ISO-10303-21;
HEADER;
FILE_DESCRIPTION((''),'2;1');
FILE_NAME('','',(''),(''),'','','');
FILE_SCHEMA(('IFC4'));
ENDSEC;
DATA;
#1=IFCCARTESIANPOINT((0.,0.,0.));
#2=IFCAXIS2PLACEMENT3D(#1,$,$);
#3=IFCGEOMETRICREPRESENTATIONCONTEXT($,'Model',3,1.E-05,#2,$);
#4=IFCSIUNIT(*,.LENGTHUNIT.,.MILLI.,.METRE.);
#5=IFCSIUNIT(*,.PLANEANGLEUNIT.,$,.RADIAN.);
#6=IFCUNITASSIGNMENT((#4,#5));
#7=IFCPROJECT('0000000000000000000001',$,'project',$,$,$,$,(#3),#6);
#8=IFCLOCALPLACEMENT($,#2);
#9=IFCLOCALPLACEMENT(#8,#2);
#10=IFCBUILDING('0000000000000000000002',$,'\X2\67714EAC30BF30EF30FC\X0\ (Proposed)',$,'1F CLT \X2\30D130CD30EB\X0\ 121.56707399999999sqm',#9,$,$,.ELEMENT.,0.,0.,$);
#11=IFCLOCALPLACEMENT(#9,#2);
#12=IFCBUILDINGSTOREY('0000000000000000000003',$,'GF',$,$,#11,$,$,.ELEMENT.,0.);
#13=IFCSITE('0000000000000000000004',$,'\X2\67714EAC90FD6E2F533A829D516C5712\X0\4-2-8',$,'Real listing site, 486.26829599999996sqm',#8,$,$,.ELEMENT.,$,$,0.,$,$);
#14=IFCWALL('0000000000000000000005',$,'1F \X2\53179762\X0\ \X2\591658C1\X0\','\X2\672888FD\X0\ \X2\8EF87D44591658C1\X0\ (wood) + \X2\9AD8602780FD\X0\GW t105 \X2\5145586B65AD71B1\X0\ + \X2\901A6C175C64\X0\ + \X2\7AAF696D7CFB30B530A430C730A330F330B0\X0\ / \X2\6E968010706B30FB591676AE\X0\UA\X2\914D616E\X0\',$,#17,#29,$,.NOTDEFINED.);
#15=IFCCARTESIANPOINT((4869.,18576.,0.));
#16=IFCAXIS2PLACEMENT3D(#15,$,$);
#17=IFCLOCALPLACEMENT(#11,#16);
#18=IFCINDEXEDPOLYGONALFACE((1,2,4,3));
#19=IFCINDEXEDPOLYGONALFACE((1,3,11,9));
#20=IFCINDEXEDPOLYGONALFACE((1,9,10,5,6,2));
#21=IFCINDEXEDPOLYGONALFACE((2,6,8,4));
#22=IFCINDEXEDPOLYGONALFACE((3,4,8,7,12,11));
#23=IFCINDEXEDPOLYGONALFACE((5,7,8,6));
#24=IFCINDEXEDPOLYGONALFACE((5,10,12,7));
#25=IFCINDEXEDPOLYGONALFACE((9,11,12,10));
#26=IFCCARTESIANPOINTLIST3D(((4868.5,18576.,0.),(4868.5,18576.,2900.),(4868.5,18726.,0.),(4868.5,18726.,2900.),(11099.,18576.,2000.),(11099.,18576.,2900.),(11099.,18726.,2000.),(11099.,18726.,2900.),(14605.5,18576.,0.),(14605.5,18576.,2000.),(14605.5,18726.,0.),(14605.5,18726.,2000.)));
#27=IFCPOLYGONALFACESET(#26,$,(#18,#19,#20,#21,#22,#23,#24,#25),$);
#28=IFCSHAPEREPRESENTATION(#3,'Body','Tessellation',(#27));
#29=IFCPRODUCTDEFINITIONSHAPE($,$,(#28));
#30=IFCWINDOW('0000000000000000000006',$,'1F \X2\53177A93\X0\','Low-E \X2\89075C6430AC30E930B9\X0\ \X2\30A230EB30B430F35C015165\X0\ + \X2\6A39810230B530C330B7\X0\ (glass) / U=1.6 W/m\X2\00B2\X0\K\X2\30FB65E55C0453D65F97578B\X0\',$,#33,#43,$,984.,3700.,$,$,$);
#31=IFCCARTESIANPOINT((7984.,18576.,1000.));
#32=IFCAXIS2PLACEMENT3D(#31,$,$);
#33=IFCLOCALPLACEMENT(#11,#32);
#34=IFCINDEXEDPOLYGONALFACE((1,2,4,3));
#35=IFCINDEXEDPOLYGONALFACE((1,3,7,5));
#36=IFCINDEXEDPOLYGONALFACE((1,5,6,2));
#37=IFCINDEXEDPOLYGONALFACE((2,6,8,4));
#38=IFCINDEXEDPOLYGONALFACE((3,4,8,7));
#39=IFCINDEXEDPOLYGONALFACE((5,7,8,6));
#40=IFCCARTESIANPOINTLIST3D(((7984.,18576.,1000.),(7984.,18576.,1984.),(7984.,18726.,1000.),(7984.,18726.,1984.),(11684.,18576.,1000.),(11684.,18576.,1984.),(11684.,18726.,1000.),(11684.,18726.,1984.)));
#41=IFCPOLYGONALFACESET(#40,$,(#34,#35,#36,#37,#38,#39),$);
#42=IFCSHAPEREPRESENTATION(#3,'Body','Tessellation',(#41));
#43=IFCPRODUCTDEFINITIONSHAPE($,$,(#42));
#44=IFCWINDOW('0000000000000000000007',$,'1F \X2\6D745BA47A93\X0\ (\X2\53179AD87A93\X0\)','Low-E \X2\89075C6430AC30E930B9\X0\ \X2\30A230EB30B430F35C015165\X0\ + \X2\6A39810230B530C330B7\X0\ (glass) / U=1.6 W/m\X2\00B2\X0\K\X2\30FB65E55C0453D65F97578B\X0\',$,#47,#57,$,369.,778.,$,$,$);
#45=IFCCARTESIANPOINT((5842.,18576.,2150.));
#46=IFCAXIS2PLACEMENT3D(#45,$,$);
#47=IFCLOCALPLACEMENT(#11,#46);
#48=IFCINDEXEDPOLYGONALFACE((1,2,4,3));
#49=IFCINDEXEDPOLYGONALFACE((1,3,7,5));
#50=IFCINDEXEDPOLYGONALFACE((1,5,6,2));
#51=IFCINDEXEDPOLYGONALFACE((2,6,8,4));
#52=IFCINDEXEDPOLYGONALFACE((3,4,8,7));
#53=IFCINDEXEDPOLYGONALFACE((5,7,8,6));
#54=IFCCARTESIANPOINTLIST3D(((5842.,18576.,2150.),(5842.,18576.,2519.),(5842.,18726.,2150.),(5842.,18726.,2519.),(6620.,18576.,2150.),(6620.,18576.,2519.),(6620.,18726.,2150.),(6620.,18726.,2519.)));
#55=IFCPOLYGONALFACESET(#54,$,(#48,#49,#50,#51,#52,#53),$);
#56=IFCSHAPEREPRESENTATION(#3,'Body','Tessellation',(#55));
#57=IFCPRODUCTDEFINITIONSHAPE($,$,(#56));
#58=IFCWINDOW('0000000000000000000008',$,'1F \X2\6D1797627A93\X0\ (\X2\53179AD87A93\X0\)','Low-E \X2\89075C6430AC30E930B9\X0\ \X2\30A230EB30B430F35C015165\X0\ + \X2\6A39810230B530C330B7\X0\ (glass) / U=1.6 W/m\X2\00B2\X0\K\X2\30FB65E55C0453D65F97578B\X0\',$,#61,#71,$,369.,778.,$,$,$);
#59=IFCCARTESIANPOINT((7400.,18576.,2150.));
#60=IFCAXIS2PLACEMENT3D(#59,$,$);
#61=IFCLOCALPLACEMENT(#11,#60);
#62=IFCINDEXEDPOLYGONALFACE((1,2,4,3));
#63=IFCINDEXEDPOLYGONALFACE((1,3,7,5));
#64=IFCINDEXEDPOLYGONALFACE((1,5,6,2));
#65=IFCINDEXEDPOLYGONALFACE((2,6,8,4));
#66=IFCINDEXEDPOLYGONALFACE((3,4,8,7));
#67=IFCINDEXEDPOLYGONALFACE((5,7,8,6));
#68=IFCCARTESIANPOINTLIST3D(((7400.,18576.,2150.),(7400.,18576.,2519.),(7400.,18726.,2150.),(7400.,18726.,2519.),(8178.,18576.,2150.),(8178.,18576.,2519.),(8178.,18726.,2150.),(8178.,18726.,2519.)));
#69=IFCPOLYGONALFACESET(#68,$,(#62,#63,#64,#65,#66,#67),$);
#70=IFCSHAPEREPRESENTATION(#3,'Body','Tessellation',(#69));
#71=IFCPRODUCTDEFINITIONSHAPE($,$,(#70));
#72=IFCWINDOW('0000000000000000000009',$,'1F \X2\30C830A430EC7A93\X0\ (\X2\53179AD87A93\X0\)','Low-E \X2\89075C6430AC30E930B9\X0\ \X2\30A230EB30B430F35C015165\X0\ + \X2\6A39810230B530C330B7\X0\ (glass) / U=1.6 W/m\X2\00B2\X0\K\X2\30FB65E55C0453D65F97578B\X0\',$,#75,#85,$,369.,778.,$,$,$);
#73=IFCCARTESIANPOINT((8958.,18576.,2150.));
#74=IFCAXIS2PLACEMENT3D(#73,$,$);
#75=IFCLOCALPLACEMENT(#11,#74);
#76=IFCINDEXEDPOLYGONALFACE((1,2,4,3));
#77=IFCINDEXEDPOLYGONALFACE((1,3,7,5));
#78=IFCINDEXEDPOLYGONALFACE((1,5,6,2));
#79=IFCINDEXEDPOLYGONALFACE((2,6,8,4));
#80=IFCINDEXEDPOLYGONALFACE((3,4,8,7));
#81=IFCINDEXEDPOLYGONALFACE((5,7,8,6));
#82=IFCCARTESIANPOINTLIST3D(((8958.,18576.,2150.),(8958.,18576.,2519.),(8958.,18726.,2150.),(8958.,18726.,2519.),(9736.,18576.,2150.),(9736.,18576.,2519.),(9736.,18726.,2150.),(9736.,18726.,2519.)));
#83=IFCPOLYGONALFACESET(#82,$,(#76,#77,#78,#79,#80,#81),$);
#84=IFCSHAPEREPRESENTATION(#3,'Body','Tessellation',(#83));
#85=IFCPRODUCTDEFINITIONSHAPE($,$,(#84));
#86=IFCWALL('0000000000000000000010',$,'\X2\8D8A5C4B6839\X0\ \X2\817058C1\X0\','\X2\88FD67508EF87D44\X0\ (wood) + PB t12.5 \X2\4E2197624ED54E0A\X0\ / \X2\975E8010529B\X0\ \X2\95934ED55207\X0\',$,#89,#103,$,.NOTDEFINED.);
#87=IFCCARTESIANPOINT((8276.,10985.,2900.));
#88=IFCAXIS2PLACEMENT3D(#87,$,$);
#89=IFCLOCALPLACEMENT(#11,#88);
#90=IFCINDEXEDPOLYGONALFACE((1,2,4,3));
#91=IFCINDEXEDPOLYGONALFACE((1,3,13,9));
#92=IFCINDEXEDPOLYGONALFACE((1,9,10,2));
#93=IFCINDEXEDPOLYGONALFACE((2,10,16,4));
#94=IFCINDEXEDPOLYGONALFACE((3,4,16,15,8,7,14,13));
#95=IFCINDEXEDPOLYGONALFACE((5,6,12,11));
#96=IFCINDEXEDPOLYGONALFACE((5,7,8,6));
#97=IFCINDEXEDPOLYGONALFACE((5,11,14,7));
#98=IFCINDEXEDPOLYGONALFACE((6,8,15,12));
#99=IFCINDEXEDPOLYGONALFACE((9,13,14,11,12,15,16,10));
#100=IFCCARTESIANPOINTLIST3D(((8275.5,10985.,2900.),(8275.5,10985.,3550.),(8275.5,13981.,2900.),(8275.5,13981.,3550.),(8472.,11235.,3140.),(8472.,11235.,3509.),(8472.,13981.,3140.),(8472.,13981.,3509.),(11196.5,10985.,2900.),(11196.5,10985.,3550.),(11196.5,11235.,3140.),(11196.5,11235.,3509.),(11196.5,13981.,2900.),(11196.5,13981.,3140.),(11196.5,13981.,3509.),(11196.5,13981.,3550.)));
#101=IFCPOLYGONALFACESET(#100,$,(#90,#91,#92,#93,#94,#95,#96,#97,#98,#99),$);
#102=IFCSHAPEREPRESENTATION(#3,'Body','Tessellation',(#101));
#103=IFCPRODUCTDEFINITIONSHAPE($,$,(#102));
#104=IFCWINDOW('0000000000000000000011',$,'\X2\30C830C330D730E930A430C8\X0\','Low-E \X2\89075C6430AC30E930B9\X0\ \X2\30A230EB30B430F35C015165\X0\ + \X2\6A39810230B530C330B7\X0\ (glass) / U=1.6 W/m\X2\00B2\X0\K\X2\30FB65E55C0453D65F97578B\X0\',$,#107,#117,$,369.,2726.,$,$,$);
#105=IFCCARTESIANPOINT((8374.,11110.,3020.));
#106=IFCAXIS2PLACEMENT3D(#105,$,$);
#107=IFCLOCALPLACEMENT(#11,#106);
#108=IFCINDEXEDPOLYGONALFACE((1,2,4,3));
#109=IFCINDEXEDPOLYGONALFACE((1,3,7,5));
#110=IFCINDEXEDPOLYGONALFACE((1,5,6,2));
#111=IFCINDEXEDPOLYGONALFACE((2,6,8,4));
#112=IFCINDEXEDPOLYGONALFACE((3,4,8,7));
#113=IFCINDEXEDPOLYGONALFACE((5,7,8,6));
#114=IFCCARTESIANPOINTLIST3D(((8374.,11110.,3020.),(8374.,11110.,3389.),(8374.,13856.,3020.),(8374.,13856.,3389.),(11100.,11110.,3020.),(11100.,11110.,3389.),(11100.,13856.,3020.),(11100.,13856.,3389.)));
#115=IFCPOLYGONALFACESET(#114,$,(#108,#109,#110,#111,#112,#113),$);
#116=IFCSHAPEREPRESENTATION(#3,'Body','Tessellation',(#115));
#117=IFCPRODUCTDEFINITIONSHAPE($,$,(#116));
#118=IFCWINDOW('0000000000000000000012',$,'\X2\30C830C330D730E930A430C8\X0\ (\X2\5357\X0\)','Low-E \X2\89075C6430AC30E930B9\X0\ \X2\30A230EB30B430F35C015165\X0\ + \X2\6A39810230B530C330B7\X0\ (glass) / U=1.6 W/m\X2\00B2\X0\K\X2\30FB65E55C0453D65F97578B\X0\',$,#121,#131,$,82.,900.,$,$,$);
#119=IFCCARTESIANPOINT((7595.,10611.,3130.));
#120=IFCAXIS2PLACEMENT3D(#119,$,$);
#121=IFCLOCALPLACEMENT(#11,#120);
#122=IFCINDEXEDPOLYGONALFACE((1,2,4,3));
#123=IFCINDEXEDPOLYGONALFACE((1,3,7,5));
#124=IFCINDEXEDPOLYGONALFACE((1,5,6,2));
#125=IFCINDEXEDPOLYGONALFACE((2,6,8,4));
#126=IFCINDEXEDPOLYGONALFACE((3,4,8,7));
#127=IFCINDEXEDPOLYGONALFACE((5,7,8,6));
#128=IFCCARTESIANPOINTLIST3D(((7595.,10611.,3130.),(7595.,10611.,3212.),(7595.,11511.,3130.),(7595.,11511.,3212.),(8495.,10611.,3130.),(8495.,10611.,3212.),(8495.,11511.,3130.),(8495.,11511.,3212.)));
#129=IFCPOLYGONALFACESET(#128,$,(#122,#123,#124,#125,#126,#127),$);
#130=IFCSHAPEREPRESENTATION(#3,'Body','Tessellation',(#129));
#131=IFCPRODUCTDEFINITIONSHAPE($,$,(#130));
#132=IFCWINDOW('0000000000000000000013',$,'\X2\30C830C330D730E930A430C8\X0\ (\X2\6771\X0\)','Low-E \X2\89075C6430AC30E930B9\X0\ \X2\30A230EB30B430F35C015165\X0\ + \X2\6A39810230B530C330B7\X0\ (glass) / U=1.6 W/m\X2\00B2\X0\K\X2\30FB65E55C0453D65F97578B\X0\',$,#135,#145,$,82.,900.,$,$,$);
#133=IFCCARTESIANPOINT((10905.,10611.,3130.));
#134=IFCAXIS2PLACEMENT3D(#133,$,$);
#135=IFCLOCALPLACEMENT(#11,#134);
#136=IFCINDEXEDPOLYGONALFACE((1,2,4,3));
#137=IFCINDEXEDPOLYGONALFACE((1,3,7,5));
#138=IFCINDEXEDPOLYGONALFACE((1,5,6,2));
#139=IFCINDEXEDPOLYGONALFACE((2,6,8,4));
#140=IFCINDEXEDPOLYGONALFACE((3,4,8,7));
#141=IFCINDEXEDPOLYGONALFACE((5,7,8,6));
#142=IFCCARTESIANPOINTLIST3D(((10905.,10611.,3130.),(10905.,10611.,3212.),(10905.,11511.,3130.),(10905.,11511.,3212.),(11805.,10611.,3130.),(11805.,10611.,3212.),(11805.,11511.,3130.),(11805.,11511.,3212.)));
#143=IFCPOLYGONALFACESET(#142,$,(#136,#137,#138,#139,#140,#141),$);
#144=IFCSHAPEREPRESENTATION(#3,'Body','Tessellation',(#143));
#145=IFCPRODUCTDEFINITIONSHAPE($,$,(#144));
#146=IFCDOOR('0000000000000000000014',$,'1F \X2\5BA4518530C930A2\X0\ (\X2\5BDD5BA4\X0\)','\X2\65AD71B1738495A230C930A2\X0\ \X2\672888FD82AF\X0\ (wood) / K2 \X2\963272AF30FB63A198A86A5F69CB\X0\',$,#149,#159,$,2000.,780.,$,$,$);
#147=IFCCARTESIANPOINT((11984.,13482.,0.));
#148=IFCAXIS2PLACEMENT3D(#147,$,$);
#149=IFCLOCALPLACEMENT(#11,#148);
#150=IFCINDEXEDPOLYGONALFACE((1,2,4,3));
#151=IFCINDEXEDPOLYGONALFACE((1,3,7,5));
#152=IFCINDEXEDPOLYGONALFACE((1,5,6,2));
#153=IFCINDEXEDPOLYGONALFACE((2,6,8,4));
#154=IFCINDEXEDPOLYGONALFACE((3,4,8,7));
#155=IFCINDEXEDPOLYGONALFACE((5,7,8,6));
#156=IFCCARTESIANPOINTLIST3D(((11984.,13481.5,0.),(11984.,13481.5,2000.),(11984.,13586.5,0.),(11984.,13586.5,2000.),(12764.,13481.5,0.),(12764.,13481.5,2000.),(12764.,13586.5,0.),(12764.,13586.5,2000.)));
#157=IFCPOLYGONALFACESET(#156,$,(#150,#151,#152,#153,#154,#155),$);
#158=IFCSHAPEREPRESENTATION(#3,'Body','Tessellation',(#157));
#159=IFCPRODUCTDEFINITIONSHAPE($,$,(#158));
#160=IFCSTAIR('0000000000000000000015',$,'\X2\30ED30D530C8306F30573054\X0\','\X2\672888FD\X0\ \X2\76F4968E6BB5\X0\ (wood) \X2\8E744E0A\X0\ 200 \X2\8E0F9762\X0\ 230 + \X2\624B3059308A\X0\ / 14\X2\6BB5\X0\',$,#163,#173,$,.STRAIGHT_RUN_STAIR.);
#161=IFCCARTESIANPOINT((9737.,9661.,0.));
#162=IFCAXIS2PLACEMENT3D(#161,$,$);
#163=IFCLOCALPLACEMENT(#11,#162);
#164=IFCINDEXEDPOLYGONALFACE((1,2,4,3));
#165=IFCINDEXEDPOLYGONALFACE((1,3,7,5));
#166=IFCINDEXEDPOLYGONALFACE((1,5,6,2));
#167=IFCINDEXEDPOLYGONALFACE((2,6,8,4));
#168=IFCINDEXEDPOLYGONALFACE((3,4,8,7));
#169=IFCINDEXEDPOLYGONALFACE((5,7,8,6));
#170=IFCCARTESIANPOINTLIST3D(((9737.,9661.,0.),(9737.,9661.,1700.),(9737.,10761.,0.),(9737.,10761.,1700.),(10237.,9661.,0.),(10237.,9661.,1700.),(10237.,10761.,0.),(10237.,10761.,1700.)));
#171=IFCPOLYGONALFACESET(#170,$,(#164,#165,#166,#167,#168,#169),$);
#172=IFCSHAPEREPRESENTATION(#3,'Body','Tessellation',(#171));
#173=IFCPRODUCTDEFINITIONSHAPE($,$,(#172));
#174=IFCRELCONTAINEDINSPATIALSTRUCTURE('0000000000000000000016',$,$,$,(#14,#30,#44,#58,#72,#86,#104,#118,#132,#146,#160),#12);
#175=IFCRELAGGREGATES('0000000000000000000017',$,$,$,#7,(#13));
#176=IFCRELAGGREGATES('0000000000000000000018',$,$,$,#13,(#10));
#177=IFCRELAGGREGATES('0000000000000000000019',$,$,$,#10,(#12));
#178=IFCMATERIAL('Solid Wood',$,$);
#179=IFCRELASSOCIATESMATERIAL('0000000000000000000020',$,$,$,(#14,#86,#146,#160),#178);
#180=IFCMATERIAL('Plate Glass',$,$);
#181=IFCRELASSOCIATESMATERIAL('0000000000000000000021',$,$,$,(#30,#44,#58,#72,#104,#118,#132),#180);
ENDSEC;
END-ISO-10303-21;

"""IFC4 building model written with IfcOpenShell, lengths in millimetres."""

from ifc_helpers import new_model, si_unit, frame, frame_2d, origin, place, context, project, spatial, rectangle, extrude, material, element, fill, save


model = new_model("IFC4")

# Units and contexts
model_context = context("Model", 3, precision=1e-05, world=origin())
ifc_project = project(units=[si_unit("LENGTHUNIT", "METRE", prefix="MILLI"), si_unit("PLANEANGLEUNIT", "RADIAN")], contexts=[model_context])

# Site, building, storey
site_placement = place(None, origin())
site = spatial("IfcSite", under=ifc_project, at=site_placement, Name="東京都港区芝公園4-2-8", ObjectType="Real listing site, 486.26829599999996sqm", CompositionType="ELEMENT", RefElevation=0.0)
building_placement = place(site_placement, origin())
building = spatial("IfcBuilding", under=site, at=building_placement, Name="東京タワー (Proposed)", ObjectType="1F CLT パネル 121.56707399999999sqm", CompositionType="ELEMENT", ElevationOfRefHeight=0.0, ElevationOfTerrain=0.0)
storey_placement = place(building_placement, origin())
storey = spatial("IfcBuildingStorey", under=building, at=storey_placement, Name="GF", CompositionType="ELEMENT", Elevation=0.0)

# Shared definitions
ifc_material_1 = material(Name="Solid Wood")

# Wall, openings, windows
wall_1_placement = place(storey_placement, frame((4869.0, 18576.0, 0.0)))
wall_1 = element("IfcWall", 1, at=wall_1_placement, inside=storey, material=ifc_material_1, Name="1F 北面 外壁", Description="木製 軸組外壁 (wood) + 高性能GW t105 充填断熱 + 通気層 + 窯業系サイディング / 準耐火・外皮UA配慮", PredefinedType="NOTDEFINED", context=model_context, shape_type="SweptSolid", body=[
    extrude(rectangle(XDim=9737.0, YDim=150.0, at=frame_2d((4868.0, 75.0))), frame((4869.0, 18576.0, 0.0)), (0.0, 0.0, 1.0), 2900.0),
])
opening_1_placement = place(storey_placement, frame((7984.0, 18576.0, 1000.0)))
opening_1 = element("IfcOpeningElement", 2, at=opening_1_placement, cuts=wall_1, PredefinedType="NOTDEFINED", context=model_context, shape_type="SweptSolid", body=[
    extrude(rectangle(XDim=3700.0, YDim=150.0, at=frame_2d((1850.0, 75.0))), frame((7984.0, 18576.0, 1000.0)), (0.0, 0.0, 1.0), 984.0),
])
opening_2_placement = place(storey_placement, frame((5842.0, 18576.0, 2150.0)))
opening_2 = element("IfcOpeningElement", 3, at=opening_2_placement, cuts=wall_1, PredefinedType="NOTDEFINED", context=model_context, shape_type="SweptSolid", body=[
    extrude(rectangle(XDim=778.0, YDim=150.0, at=frame_2d((389.0, 75.0))), frame((5842.0, 18576.0, 2150.0)), (0.0, 0.0, 1.0), 369.0),
])
opening_3_placement = place(storey_placement, frame((7400.0, 18576.0, 2150.0)))
opening_3 = element("IfcOpeningElement", 4, at=opening_3_placement, cuts=wall_1, PredefinedType="NOTDEFINED", context=model_context, shape_type="SweptSolid", body=[
    extrude(rectangle(XDim=778.0, YDim=150.0, at=frame_2d((389.0, 75.0))), frame((7400.0, 18576.0, 2150.0)), (0.0, 0.0, 1.0), 369.0),
])
opening_4_placement = place(storey_placement, frame((8958.0, 18576.0, 2150.0)))
opening_4 = element("IfcOpeningElement", 5, at=opening_4_placement, cuts=wall_1, PredefinedType="NOTDEFINED", context=model_context, shape_type="SweptSolid", body=[
    extrude(rectangle(XDim=778.0, YDim=150.0, at=frame_2d((389.0, 75.0))), frame((8958.0, 18576.0, 2150.0)), (0.0, 0.0, 1.0), 369.0),
])
ifc_material_2 = material(Name="Plate Glass")
window_1_placement = place(storey_placement, frame((7984.0, 18576.0, 1000.0)))
window_1 = element("IfcWindow", 6, at=window_1_placement, inside=storey, material=ifc_material_2, Name="1F 北窓", Description="Low-E 複層ガラス アルゴン封入 + 樹脂サッシ (glass) / U=1.6 W/m²K・日射取得型", OverallHeight=984.0, OverallWidth=3700.0, context=model_context, shape_type="SweptSolid", body=[
    extrude(rectangle(XDim=3700.0, YDim=150.0, at=frame_2d((1850.0, 75.0))), frame((7984.0, 18576.0, 1000.0)), (0.0, 0.0, 1.0), 984.0),
])
fill(opening_1, window_1)
window_2_placement = place(storey_placement, frame((5842.0, 18576.0, 2150.0)))
window_2 = element("IfcWindow", 7, at=window_2_placement, inside=storey, material=ifc_material_2, Name="1F 浴室窓 (北高窓)", Description="Low-E 複層ガラス アルゴン封入 + 樹脂サッシ (glass) / U=1.6 W/m²K・日射取得型", OverallHeight=369.0, OverallWidth=778.0, context=model_context, shape_type="SweptSolid", body=[
    extrude(rectangle(XDim=778.0, YDim=150.0, at=frame_2d((389.0, 75.0))), frame((5842.0, 18576.0, 2150.0)), (0.0, 0.0, 1.0), 369.0),
])
fill(opening_2, window_2)
window_3_placement = place(storey_placement, frame((7400.0, 18576.0, 2150.0)))
window_3 = element("IfcWindow", 8, at=window_3_placement, inside=storey, material=ifc_material_2, Name="1F 洗面窓 (北高窓)", Description="Low-E 複層ガラス アルゴン封入 + 樹脂サッシ (glass) / U=1.6 W/m²K・日射取得型", OverallHeight=369.0, OverallWidth=778.0, context=model_context, shape_type="SweptSolid", body=[
    extrude(rectangle(XDim=778.0, YDim=150.0, at=frame_2d((389.0, 75.0))), frame((7400.0, 18576.0, 2150.0)), (0.0, 0.0, 1.0), 369.0),
])
fill(opening_3, window_3)
window_4_placement = place(storey_placement, frame((8958.0, 18576.0, 2150.0)))
window_4 = element("IfcWindow", 9, at=window_4_placement, inside=storey, material=ifc_material_2, Name="1F トイレ窓 (北高窓)", Description="Low-E 複層ガラス アルゴン封入 + 樹脂サッシ (glass) / U=1.6 W/m²K・日射取得型", OverallHeight=369.0, OverallWidth=778.0, context=model_context, shape_type="SweptSolid", body=[
    extrude(rectangle(XDim=778.0, YDim=150.0, at=frame_2d((389.0, 75.0))), frame((8958.0, 18576.0, 2150.0)), (0.0, 0.0, 1.0), 369.0),
])
fill(opening_4, window_4)

# Wall, openings, windows
wall_2_placement = place(storey_placement, frame((8276.0, 10985.0, 2900.0)))
wall_2 = element("IfcWall", 10, at=wall_2_placement, inside=storey, material=ifc_material_1, Name="越屋根 腰壁", Description="製材軸組 (wood) + PB t12.5 両面仕上 / 非耐力 間仕切", PredefinedType="NOTDEFINED", context=model_context, shape_type="SweptSolid", body=[
    extrude(rectangle(XDim=2921.0, YDim=2996.0, at=frame_2d((1460.0, 1498.0))), frame((8276.0, 10985.0, 2900.0)), (0.0, 0.0, 1.0), 650.0),
])
opening_5_placement = place(storey_placement, frame((8374.0, 11110.0, 3020.0)))
opening_5 = element("IfcOpeningElement", 11, at=opening_5_placement, cuts=wall_2, PredefinedType="NOTDEFINED", context=model_context, shape_type="SweptSolid", body=[
    extrude(rectangle(XDim=2726.0, YDim=2746.0, at=frame_2d((1363.0, 1373.0))), frame((8374.0, 11110.0, 3020.0)), (0.0, 0.0, 1.0), 369.0),
])
opening_6_placement = place(storey_placement, frame((7595.0, 10611.0, 3130.0)))
opening_6 = element("IfcOpeningElement", 12, at=opening_6_placement, cuts=wall_2, PredefinedType="NOTDEFINED", context=model_context, shape_type="SweptSolid", body=[
    extrude(rectangle(XDim=900.0, YDim=900.0, at=frame_2d((450.0, 450.0))), frame((7595.0, 10611.0, 3130.0)), (0.0, 0.0, 1.0), 82.0),
])
opening_7_placement = place(storey_placement, frame((10905.0, 10611.0, 3130.0)))
opening_7 = element("IfcOpeningElement", 13, at=opening_7_placement, cuts=wall_2, PredefinedType="NOTDEFINED", context=model_context, shape_type="SweptSolid", body=[
    extrude(rectangle(XDim=900.0, YDim=900.0, at=frame_2d((450.0, 450.0))), frame((10905.0, 10611.0, 3130.0)), (0.0, 0.0, 1.0), 82.0),
])
window_5_placement = place(storey_placement, frame((8374.0, 11110.0, 3020.0)))
window_5 = element("IfcWindow", 14, at=window_5_placement, inside=storey, material=ifc_material_2, Name="トップライト", Description="Low-E 複層ガラス アルゴン封入 + 樹脂サッシ (glass) / U=1.6 W/m²K・日射取得型", OverallHeight=369.0, OverallWidth=2726.0, context=model_context, shape_type="SweptSolid", body=[
    extrude(rectangle(XDim=2726.0, YDim=2746.0, at=frame_2d((1363.0, 1373.0))), frame((8374.0, 11110.0, 3020.0)), (0.0, 0.0, 1.0), 369.0),
])
fill(opening_5, window_5)
window_6_placement = place(storey_placement, frame((7595.0, 10611.0, 3130.0)))
window_6 = element("IfcWindow", 15, at=window_6_placement, inside=storey, material=ifc_material_2, Name="トップライト (南)", Description="Low-E 複層ガラス アルゴン封入 + 樹脂サッシ (glass) / U=1.6 W/m²K・日射取得型", OverallHeight=82.0, OverallWidth=900.0, context=model_context, shape_type="SweptSolid", body=[
    extrude(rectangle(XDim=900.0, YDim=900.0, at=frame_2d((450.0, 450.0))), frame((7595.0, 10611.0, 3130.0)), (0.0, 0.0, 1.0), 82.0),
])
fill(opening_6, window_6)
window_7_placement = place(storey_placement, frame((10905.0, 10611.0, 3130.0)))
window_7 = element("IfcWindow", 16, at=window_7_placement, inside=storey, material=ifc_material_2, Name="トップライト (東)", Description="Low-E 複層ガラス アルゴン封入 + 樹脂サッシ (glass) / U=1.6 W/m²K・日射取得型", OverallHeight=82.0, OverallWidth=900.0, context=model_context, shape_type="SweptSolid", body=[
    extrude(rectangle(XDim=900.0, YDim=900.0, at=frame_2d((450.0, 450.0))), frame((10905.0, 10611.0, 3130.0)), (0.0, 0.0, 1.0), 82.0),
])
fill(opening_7, window_7)

# Door
door_1_placement = place(storey_placement, frame((11984.0, 13482.0, 0.0)))
element("IfcDoor", 17, at=door_1_placement, inside=storey, material=ifc_material_1, Name="1F 室内ドア (寝室)", Description="断熱玄関ドア 木製芯 (wood) / K2 防犯・採風機構", OverallHeight=2000.0, OverallWidth=780.0, context=model_context, shape_type="SweptSolid", body=[
    extrude(rectangle(XDim=780.0, YDim=105.0, at=frame_2d((390.0, 52.0))), frame((11984.0, 13482.0, 0.0)), (0.0, 0.0, 1.0), 2000.0),
])

# Stair
stair_placement = place(storey_placement, frame((9737.0, 9661.0, 0.0)))
element("IfcStair", 18, at=stair_placement, inside=storey, material=ifc_material_1, Name="ロフトはしご", Description="木製 直階段 (wood) 蹴上 200 踏面 230 + 手すり / 14段", PredefinedType="STRAIGHT_RUN_STAIR", context=model_context, shape_type="SweptSolid", body=[
    extrude(rectangle(XDim=500.0, YDim=1100.0, at=frame_2d((250.0, 550.0))), frame((9737.0, 9661.0, 0.0)), (0.0, 0.0, 1.0), 1700.0),
])

save(model, "model.ifc")
